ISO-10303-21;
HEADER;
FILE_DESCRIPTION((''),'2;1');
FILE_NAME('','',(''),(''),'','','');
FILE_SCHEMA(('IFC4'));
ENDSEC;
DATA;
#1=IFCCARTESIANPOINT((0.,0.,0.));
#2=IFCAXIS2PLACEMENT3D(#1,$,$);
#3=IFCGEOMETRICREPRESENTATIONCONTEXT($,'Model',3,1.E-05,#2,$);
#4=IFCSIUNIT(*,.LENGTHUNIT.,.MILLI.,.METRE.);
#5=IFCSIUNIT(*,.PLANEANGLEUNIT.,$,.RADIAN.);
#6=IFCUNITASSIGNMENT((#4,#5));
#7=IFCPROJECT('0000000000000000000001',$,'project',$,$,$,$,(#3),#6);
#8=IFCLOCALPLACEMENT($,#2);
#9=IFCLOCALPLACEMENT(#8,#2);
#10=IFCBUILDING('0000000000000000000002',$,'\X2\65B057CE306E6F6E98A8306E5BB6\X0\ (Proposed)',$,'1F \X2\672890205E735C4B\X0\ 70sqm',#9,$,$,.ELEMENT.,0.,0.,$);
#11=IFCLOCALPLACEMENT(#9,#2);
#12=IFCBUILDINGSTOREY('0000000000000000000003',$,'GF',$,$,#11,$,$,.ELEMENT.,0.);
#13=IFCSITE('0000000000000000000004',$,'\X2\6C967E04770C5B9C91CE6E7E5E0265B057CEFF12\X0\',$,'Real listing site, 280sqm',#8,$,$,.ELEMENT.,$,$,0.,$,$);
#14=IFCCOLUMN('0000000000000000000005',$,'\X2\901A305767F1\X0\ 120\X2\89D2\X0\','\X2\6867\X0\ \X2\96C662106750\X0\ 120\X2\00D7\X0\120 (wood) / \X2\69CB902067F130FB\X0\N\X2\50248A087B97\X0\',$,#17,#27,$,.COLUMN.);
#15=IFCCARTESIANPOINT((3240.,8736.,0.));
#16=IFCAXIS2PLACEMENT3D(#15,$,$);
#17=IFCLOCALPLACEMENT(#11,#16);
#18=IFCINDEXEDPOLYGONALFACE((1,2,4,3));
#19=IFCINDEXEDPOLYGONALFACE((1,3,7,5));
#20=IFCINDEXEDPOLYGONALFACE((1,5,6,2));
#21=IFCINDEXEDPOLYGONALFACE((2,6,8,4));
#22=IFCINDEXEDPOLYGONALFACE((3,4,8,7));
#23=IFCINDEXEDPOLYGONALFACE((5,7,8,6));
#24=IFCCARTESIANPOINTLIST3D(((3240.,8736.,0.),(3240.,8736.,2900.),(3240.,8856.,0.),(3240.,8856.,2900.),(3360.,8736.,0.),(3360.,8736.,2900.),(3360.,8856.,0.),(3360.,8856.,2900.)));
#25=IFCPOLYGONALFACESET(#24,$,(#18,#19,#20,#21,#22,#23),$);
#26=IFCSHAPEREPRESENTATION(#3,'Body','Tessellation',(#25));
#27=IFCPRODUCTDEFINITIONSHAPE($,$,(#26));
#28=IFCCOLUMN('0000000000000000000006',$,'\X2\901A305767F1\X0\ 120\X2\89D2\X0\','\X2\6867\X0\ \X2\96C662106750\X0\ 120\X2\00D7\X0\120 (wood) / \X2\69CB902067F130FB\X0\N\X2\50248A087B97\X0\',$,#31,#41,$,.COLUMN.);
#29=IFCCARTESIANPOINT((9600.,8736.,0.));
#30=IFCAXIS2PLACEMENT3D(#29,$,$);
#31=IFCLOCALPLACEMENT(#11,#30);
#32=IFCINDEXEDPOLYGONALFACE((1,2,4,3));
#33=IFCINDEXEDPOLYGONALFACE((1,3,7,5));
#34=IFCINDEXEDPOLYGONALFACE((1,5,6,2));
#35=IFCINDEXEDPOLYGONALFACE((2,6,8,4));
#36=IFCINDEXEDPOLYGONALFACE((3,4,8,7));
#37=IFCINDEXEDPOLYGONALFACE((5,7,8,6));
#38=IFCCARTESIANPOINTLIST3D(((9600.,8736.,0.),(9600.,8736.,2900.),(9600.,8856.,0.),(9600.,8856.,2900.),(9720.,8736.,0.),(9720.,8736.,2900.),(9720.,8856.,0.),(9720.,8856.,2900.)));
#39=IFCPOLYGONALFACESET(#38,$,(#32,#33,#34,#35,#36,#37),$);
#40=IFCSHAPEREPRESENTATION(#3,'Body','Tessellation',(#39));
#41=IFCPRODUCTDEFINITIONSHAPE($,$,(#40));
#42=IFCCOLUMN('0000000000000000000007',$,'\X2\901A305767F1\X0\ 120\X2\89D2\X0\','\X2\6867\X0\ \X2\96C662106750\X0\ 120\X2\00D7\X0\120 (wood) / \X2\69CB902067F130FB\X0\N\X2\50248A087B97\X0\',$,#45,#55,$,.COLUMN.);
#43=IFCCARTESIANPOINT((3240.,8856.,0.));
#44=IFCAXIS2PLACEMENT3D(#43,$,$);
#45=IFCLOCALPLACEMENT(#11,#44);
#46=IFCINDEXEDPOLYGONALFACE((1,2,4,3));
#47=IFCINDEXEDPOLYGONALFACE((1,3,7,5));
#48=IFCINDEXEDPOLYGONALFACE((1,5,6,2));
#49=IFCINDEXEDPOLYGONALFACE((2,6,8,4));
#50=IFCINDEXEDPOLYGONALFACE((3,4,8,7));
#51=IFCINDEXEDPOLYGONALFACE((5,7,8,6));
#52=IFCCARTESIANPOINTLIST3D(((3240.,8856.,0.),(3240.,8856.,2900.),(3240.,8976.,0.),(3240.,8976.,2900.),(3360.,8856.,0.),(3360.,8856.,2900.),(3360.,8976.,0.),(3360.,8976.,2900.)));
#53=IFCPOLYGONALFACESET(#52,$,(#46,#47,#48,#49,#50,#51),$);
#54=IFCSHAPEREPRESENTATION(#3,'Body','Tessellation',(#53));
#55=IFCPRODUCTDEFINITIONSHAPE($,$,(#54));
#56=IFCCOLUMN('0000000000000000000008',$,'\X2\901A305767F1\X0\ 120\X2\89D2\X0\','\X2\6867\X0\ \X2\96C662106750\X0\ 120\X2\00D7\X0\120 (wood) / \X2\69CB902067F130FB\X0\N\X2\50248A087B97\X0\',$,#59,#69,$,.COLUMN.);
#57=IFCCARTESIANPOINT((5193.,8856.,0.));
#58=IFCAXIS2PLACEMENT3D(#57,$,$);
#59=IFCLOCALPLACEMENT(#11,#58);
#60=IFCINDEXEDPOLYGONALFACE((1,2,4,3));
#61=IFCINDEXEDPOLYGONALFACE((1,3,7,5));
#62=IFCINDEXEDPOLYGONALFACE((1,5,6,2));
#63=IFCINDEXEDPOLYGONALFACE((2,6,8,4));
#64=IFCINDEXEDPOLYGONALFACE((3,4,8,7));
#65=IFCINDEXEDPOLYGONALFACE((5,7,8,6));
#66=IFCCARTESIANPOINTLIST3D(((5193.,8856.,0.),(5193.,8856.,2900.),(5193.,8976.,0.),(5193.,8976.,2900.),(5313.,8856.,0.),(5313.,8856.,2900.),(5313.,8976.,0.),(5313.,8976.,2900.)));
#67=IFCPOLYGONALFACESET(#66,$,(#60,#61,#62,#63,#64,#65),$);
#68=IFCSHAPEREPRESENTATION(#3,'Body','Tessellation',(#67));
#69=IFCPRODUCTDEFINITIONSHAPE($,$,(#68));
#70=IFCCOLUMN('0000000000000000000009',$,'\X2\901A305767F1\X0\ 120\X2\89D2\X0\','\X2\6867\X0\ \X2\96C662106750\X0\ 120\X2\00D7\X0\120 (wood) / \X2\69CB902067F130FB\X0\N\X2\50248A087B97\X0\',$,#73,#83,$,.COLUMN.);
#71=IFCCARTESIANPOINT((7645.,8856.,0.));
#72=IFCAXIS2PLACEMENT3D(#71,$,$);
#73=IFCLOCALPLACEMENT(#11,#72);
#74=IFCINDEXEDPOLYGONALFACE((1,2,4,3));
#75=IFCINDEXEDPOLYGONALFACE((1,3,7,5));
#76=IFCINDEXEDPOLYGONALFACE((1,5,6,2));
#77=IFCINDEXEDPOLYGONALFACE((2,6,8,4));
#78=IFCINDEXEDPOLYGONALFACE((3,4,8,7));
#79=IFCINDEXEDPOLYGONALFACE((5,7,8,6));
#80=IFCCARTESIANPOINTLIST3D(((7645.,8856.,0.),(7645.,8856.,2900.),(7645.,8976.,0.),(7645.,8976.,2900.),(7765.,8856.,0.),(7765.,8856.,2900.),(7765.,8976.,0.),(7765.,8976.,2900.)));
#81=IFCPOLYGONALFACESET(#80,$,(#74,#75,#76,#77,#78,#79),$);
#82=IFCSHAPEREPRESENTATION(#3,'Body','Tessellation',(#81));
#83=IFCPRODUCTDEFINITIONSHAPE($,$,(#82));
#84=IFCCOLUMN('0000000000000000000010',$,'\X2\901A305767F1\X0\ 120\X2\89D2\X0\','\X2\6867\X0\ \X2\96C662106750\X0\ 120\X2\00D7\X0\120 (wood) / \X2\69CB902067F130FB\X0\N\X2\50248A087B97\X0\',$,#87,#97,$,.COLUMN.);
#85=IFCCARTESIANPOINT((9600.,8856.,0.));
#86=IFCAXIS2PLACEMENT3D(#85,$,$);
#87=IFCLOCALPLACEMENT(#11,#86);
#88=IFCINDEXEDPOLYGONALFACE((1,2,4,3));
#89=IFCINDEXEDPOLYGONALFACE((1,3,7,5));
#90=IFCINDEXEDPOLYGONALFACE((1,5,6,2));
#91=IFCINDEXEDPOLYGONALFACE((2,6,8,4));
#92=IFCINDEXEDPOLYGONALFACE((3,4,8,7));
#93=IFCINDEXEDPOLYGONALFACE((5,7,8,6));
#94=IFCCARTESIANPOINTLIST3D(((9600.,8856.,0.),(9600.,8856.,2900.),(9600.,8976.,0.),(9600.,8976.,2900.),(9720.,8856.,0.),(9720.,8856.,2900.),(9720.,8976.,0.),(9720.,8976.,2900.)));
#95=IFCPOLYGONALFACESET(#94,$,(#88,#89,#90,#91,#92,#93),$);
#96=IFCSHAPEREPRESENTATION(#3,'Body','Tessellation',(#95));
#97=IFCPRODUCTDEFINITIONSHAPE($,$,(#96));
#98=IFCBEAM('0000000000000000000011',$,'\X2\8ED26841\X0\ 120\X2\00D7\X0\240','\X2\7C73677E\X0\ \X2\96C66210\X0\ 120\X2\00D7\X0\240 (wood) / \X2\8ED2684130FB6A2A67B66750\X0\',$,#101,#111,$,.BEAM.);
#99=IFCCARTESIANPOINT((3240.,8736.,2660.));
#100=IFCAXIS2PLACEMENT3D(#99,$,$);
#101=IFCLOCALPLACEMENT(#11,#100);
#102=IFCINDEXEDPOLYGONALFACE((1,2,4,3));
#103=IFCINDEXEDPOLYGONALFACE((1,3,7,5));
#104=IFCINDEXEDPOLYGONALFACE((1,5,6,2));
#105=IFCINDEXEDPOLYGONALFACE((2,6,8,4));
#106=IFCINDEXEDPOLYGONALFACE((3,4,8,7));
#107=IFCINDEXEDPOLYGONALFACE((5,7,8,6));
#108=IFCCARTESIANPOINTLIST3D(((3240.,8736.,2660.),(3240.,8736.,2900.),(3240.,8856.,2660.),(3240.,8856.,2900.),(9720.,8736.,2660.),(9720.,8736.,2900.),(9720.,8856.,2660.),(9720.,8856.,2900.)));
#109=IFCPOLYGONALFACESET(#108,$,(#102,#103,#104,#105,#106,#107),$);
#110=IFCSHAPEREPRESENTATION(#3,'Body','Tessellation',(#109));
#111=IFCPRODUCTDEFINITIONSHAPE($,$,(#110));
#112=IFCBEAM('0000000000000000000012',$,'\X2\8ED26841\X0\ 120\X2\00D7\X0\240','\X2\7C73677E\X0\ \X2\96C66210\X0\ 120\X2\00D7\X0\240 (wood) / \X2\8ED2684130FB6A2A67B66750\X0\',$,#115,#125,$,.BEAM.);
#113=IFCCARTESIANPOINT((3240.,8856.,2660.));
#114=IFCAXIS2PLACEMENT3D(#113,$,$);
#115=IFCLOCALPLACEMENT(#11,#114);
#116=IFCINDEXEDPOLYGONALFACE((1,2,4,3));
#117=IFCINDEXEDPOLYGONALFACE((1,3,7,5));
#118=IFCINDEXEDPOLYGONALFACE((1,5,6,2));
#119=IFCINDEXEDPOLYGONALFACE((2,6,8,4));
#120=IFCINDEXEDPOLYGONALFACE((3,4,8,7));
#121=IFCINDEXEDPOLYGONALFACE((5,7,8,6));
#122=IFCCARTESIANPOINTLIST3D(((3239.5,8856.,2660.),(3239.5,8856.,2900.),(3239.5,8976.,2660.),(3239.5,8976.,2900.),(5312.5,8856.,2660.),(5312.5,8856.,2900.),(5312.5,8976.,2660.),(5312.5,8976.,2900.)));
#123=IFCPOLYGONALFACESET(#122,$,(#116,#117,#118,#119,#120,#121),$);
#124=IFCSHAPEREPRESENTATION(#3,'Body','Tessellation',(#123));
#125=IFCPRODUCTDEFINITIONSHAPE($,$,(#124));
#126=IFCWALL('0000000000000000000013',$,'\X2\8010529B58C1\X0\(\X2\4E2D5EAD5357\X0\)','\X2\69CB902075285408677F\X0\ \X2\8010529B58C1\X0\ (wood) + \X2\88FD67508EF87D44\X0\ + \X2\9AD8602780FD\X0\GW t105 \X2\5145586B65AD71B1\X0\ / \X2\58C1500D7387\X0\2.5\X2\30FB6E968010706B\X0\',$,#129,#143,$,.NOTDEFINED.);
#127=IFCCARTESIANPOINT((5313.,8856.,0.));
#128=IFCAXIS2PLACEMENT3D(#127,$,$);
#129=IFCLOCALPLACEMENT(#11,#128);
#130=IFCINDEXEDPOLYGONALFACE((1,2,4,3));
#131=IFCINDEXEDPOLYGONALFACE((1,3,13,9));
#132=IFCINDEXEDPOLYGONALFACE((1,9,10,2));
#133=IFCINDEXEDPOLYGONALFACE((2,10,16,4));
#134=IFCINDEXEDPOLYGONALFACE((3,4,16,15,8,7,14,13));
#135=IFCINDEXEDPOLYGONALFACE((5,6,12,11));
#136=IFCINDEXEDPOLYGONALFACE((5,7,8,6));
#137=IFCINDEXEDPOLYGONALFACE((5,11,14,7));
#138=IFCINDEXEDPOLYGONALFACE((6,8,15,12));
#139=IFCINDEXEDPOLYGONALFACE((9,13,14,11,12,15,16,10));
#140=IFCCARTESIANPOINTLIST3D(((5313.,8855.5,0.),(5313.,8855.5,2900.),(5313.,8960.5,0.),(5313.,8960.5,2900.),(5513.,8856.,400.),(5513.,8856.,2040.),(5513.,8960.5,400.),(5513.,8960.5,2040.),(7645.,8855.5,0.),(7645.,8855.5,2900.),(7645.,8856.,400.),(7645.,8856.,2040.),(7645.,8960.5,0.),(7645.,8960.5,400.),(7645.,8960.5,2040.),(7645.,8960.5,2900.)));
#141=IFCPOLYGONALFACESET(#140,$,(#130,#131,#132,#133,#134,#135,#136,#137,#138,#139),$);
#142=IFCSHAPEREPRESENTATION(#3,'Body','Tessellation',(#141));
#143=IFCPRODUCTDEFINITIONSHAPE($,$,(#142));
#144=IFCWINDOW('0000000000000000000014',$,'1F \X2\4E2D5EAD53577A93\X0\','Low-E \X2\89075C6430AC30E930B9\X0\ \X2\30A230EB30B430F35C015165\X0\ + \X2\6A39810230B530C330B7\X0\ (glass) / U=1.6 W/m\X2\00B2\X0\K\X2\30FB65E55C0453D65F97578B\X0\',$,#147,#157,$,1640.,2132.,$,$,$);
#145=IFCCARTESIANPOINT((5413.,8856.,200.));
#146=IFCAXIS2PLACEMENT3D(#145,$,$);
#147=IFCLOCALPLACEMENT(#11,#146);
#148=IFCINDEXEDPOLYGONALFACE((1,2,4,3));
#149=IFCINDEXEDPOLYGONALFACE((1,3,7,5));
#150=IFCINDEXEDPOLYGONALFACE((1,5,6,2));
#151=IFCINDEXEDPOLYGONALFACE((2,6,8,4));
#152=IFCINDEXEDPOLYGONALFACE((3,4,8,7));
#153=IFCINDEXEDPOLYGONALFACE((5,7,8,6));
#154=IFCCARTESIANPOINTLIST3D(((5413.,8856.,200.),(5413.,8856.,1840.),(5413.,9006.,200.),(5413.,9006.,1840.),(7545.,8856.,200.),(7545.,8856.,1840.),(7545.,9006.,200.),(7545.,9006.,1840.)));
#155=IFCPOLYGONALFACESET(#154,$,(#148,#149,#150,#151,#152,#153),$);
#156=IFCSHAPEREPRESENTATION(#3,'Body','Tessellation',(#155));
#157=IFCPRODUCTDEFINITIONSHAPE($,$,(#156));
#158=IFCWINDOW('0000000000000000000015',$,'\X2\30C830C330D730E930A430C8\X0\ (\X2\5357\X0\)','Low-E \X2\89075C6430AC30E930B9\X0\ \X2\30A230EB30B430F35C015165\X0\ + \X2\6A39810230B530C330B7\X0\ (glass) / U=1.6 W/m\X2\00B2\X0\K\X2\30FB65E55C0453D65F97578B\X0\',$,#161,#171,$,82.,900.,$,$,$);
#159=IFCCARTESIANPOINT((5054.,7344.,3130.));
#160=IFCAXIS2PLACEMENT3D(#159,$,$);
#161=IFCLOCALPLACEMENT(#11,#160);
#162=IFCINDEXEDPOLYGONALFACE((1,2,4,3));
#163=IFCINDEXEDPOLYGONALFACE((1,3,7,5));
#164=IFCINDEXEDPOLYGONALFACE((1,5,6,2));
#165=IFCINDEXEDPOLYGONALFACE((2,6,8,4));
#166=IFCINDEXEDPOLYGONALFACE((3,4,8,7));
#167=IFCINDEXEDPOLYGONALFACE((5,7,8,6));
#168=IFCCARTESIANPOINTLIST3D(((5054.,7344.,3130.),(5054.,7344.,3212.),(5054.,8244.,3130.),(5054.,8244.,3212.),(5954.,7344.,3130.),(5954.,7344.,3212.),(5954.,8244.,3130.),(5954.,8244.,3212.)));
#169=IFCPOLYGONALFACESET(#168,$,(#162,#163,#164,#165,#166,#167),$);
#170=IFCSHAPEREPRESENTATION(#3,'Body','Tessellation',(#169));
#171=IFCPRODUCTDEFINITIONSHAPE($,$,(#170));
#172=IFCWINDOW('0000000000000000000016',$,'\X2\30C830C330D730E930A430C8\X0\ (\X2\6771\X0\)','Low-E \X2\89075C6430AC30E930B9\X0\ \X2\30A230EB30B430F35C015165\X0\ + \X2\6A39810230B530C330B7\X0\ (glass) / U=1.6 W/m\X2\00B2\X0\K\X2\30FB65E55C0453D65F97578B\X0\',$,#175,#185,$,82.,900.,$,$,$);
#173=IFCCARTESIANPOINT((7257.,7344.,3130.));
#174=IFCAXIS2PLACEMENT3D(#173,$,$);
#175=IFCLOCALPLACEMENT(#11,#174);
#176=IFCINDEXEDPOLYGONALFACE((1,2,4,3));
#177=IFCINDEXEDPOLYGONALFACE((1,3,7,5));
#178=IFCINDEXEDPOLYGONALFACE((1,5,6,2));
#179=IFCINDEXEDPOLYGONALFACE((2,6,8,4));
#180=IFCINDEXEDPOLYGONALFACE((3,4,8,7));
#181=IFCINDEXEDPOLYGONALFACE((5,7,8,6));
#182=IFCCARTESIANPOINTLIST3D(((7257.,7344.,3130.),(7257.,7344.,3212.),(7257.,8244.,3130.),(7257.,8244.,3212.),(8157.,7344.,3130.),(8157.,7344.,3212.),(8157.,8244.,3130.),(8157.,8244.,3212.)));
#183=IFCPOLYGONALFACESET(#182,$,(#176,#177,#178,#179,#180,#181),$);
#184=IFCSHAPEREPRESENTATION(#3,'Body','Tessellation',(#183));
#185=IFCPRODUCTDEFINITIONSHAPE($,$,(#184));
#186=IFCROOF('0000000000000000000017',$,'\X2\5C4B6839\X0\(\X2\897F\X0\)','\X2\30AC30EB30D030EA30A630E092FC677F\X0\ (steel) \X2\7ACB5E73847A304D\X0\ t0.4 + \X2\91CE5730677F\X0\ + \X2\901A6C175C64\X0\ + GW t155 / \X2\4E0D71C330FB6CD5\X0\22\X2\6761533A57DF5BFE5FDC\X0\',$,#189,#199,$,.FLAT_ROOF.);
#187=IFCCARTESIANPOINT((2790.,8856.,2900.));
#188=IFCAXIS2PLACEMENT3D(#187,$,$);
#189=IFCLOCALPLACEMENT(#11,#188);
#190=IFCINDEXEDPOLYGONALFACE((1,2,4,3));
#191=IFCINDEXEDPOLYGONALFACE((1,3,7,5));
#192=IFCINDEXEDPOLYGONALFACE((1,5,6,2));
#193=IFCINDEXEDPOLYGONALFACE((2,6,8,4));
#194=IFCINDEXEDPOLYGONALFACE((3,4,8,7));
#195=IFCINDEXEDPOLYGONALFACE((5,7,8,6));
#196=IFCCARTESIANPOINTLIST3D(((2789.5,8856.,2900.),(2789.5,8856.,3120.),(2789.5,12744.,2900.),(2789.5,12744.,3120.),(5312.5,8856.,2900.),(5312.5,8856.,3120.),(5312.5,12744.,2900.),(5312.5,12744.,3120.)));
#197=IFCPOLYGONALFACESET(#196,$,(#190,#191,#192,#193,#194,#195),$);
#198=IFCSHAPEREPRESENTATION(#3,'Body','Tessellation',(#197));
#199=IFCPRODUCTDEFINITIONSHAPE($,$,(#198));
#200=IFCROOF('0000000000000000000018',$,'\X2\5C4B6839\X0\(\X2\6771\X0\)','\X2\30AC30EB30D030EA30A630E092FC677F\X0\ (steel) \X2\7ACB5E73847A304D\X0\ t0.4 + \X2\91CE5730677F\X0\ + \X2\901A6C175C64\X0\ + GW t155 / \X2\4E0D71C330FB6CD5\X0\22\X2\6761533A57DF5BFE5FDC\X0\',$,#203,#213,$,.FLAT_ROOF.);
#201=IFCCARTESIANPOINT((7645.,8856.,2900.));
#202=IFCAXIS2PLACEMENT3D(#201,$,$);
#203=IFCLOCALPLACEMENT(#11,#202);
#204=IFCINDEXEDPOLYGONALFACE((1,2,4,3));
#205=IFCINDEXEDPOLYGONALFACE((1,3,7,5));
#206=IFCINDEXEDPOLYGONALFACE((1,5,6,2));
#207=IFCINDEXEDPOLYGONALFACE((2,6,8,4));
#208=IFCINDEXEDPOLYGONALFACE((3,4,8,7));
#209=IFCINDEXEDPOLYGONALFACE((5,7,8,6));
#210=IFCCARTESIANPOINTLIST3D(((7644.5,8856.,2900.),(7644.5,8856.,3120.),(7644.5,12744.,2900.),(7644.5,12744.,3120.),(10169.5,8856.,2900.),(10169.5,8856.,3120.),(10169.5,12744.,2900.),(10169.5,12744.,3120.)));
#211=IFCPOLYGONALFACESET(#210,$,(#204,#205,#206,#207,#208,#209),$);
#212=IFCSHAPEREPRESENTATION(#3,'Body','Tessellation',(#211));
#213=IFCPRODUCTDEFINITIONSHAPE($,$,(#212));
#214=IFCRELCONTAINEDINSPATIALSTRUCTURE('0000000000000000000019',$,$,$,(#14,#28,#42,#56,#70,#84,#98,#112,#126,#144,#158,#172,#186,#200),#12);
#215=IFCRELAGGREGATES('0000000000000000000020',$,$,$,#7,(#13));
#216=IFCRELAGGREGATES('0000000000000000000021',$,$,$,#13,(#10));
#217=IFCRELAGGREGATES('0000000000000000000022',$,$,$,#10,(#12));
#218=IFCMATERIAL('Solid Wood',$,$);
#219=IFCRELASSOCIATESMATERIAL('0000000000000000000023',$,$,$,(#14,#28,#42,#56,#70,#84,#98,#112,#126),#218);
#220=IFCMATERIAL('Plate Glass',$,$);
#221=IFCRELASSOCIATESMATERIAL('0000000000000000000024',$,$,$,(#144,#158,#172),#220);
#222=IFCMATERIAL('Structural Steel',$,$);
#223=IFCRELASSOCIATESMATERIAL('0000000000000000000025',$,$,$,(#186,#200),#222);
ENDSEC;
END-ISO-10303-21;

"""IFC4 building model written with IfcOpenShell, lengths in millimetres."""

from ifc_helpers import new_model, si_unit, frame, frame_2d, origin, place, context, project, spatial, rectangle, extrude, material, element, fill, save


model = new_model("IFC4")

# Units and contexts
model_context = context("Model", 3, precision=1e-05, world=origin())
ifc_project = project(units=[si_unit("LENGTHUNIT", "METRE", prefix="MILLI"), si_unit("PLANEANGLEUNIT", "RADIAN")], contexts=[model_context])

# Site, building, storey
site_placement = place(None, origin())
site = spatial("IfcSite", under=ifc_project, at=site_placement, Name="沖縄県宜野湾市新城２", ObjectType="Real listing site, 280sqm", CompositionType="ELEMENT", RefElevation=0.0)
building_placement = place(site_placement, origin())
building = spatial("IfcBuilding", under=site, at=building_placement, Name="新城の潮風の家 (Proposed)", ObjectType="1F 木造平屋 70sqm", CompositionType="ELEMENT", ElevationOfRefHeight=0.0, ElevationOfTerrain=0.0)
storey_placement = place(building_placement, origin())
storey = spatial("IfcBuildingStorey", under=building, at=storey_placement, Name="GF", CompositionType="ELEMENT", Elevation=0.0)

# Columns
ifc_material_1 = material(Name="Solid Wood")
column_1_placement = place(storey_placement, frame((3240.0, 8736.0, 0.0)))
element("IfcColumn", 1, at=column_1_placement, inside=storey, material=ifc_material_1, Name="通し柱 120角", Description="桧 集成材 120×120 (wood) / 構造柱・N値計算", PredefinedType="COLUMN", context=model_context, shape_type="SweptSolid", body=[
    extrude(rectangle(XDim=120.0, YDim=120.0, at=frame_2d((60.0, 60.0))), frame((3240.0, 8736.0, 0.0)), (0.0, 0.0, 1.0), 2900.0),
])
column_2_placement = place(storey_placement, frame((9600.0, 8736.0, 0.0)))
element("IfcColumn", 2, at=column_2_placement, inside=storey, material=ifc_material_1, Name="通し柱 120角", Description="桧 集成材 120×120 (wood) / 構造柱・N値計算", PredefinedType="COLUMN", context=model_context, shape_type="SweptSolid", body=[
    extrude(rectangle(XDim=120.0, YDim=120.0, at=frame_2d((60.0, 60.0))), frame((9600.0, 8736.0, 0.0)), (0.0, 0.0, 1.0), 2900.0),
])
column_3_placement = place(storey_placement, frame((3240.0, 8856.0, 0.0)))
element("IfcColumn", 3, at=column_3_placement, inside=storey, material=ifc_material_1, Name="通し柱 120角", Description="桧 集成材 120×120 (wood) / 構造柱・N値計算", PredefinedType="COLUMN", context=model_context, shape_type="SweptSolid", body=[
    extrude(rectangle(XDim=120.0, YDim=120.0, at=frame_2d((60.0, 60.0))), frame((3240.0, 8856.0, 0.0)), (0.0, 0.0, 1.0), 2900.0),
])
column_4_placement = place(storey_placement, frame((5193.0, 8856.0, 0.0)))
element("IfcColumn", 4, at=column_4_placement, inside=storey, material=ifc_material_1, Name="通し柱 120角", Description="桧 集成材 120×120 (wood) / 構造柱・N値計算", PredefinedType="COLUMN", context=model_context, shape_type="SweptSolid", body=[
    extrude(rectangle(XDim=120.0, YDim=120.0, at=frame_2d((60.0, 60.0))), frame((5193.0, 8856.0, 0.0)), (0.0, 0.0, 1.0), 2900.0),
])
column_5_placement = place(storey_placement, frame((7645.0, 8856.0, 0.0)))
element("IfcColumn", 5, at=column_5_placement, inside=storey, material=ifc_material_1, Name="通し柱 120角", Description="桧 集成材 120×120 (wood) / 構造柱・N値計算", PredefinedType="COLUMN", context=model_context, shape_type="SweptSolid", body=[
    extrude(rectangle(XDim=120.0, YDim=120.0, at=frame_2d((60.0, 60.0))), frame((7645.0, 8856.0, 0.0)), (0.0, 0.0, 1.0), 2900.0),
])
column_6_placement = place(storey_placement, frame((9600.0, 8856.0, 0.0)))
element("IfcColumn", 6, at=column_6_placement, inside=storey, material=ifc_material_1, Name="通し柱 120角", Description="桧 集成材 120×120 (wood) / 構造柱・N値計算", PredefinedType="COLUMN", context=model_context, shape_type="SweptSolid", body=[
    extrude(rectangle(XDim=120.0, YDim=120.0, at=frame_2d((60.0, 60.0))), frame((9600.0, 8856.0, 0.0)), (0.0, 0.0, 1.0), 2900.0),
])

# Beams
beam_1_placement = place(storey_placement, frame((3240.0, 8736.0, 2660.0)))
element("IfcBeam", 7, at=beam_1_placement, inside=storey, material=ifc_material_1, Name="軒桁 120×240", Description="米松 集成 120×240 (wood) / 軒桁・横架材", PredefinedType="BEAM", context=model_context, shape_type="SweptSolid", body=[
    extrude(rectangle(XDim=6480.0, YDim=120.0, at=frame_2d((3240.0, 60.0))), frame((3240.0, 8736.0, 2660.0)), (0.0, 0.0, 1.0), 240.0),
])
beam_2_placement = place(storey_placement, frame((3240.0, 8856.0, 2660.0)))
element("IfcBeam", 8, at=beam_2_placement, inside=storey, material=ifc_material_1, Name="軒桁 120×240", Description="米松 集成 120×240 (wood) / 軒桁・横架材", PredefinedType="BEAM", context=model_context, shape_type="SweptSolid", body=[
    extrude(rectangle(XDim=2073.0, YDim=120.0, at=frame_2d((1036.0, 60.0))), frame((3240.0, 8856.0, 2660.0)), (0.0, 0.0, 1.0), 240.0),
])

# Wall, opening, window
wall_1_placement = place(storey_placement, frame((5313.0, 8856.0, 0.0)))
wall_1 = element("IfcWall", 9, at=wall_1_placement, inside=storey, material=ifc_material_1, Name="耐力壁(中庭南)", Description="構造用合板 耐力壁 (wood) + 製材軸組 + 高性能GW t105 充填断熱 / 壁倍率2.5・準耐火", PredefinedType="NOTDEFINED", context=model_context, shape_type="SweptSolid", body=[
    extrude(rectangle(XDim=2332.0, YDim=105.0, at=frame_2d((1166.0, 52.0))), frame((5313.0, 8856.0, 0.0)), (0.0, 0.0, 1.0), 2900.0),
])
opening_placement = place(storey_placement, frame((5413.0, 8856.0, 200.0)))
opening = element("IfcOpeningElement", 10, at=opening_placement, cuts=wall_1, PredefinedType="NOTDEFINED", context=model_context, shape_type="SweptSolid", body=[
    extrude(rectangle(XDim=2132.0, YDim=150.0, at=frame_2d((1066.0, 75.0))), frame((5413.0, 8856.0, 200.0)), (0.0, 0.0, 1.0), 1640.0),
])
ifc_material_2 = material(Name="Plate Glass")
window_1_placement = place(storey_placement, frame((5413.0, 8856.0, 200.0)))
window_1 = element("IfcWindow", 11, at=window_1_placement, inside=storey, material=ifc_material_2, Name="1F 中庭南窓", Description="Low-E 複層ガラス アルゴン封入 + 樹脂サッシ (glass) / U=1.6 W/m²K・日射取得型", OverallHeight=1640.0, OverallWidth=2132.0, context=model_context, shape_type="SweptSolid", body=[
    extrude(rectangle(XDim=2132.0, YDim=150.0, at=frame_2d((1066.0, 75.0))), frame((5413.0, 8856.0, 200.0)), (0.0, 0.0, 1.0), 1640.0),
])
fill(opening, window_1)

# Windows
window_2_placement = place(storey_placement, frame((5054.0, 7344.0, 3130.0)))
element("IfcWindow", 12, at=window_2_placement, inside=storey, material=ifc_material_2, Name="トップライト (南)", Description="Low-E 複層ガラス アルゴン封入 + 樹脂サッシ (glass) / U=1.6 W/m²K・日射取得型", OverallHeight=82.0, OverallWidth=900.0, context=model_context, shape_type="SweptSolid", body=[
    extrude(rectangle(XDim=900.0, YDim=900.0, at=frame_2d((450.0, 450.0))), frame((5054.0, 7344.0, 3130.0)), (0.0, 0.0, 1.0), 82.0),
])
window_3_placement = place(storey_placement, frame((7257.0, 7344.0, 3130.0)))
element("IfcWindow", 13, at=window_3_placement, inside=storey, material=ifc_material_2, Name="トップライト (東)", Description="Low-E 複層ガラス アルゴン封入 + 樹脂サッシ (glass) / U=1.6 W/m²K・日射取得型", OverallHeight=82.0, OverallWidth=900.0, context=model_context, shape_type="SweptSolid", body=[
    extrude(rectangle(XDim=900.0, YDim=900.0, at=frame_2d((450.0, 450.0))), frame((7257.0, 7344.0, 3130.0)), (0.0, 0.0, 1.0), 82.0),
])

# Roofs
ifc_material_3 = material(Name="Structural Steel")
roof_1_placement = place(storey_placement, frame((2790.0, 8856.0, 2900.0)))
element("IfcRoof", 14, at=roof_1_placement, inside=storey, material=ifc_material_3, Name="屋根(西)", Description="ガルバリウム鋼板 (steel) 立平葺き t0.4 + 野地板 + 通気層 + GW t155 / 不燃・法22条区域対応", PredefinedType="FLAT_ROOF", context=model_context, shape_type="SweptSolid", body=[
    extrude(rectangle(XDim=2523.0, YDim=3888.0, at=frame_2d((1261.0, 1944.0))), frame((2790.0, 8856.0, 2900.0)), (0.0, 0.0, 1.0), 220.0),
])
roof_2_placement = place(storey_placement, frame((7645.0, 8856.0, 2900.0)))
element("IfcRoof", 15, at=roof_2_placement, inside=storey, material=ifc_material_3, Name="屋根(東)", Description="ガルバリウム鋼板 (steel) 立平葺き t0.4 + 野地板 + 通気層 + GW t155 / 不燃・法22条区域対応", PredefinedType="FLAT_ROOF", context=model_context, shape_type="SweptSolid", body=[
    extrude(rectangle(XDim=2525.0, YDim=3888.0, at=frame_2d((1262.0, 1944.0))), frame((7645.0, 8856.0, 2900.0)), (0.0, 0.0, 1.0), 220.0),
])

save(model, "model.ifc")
